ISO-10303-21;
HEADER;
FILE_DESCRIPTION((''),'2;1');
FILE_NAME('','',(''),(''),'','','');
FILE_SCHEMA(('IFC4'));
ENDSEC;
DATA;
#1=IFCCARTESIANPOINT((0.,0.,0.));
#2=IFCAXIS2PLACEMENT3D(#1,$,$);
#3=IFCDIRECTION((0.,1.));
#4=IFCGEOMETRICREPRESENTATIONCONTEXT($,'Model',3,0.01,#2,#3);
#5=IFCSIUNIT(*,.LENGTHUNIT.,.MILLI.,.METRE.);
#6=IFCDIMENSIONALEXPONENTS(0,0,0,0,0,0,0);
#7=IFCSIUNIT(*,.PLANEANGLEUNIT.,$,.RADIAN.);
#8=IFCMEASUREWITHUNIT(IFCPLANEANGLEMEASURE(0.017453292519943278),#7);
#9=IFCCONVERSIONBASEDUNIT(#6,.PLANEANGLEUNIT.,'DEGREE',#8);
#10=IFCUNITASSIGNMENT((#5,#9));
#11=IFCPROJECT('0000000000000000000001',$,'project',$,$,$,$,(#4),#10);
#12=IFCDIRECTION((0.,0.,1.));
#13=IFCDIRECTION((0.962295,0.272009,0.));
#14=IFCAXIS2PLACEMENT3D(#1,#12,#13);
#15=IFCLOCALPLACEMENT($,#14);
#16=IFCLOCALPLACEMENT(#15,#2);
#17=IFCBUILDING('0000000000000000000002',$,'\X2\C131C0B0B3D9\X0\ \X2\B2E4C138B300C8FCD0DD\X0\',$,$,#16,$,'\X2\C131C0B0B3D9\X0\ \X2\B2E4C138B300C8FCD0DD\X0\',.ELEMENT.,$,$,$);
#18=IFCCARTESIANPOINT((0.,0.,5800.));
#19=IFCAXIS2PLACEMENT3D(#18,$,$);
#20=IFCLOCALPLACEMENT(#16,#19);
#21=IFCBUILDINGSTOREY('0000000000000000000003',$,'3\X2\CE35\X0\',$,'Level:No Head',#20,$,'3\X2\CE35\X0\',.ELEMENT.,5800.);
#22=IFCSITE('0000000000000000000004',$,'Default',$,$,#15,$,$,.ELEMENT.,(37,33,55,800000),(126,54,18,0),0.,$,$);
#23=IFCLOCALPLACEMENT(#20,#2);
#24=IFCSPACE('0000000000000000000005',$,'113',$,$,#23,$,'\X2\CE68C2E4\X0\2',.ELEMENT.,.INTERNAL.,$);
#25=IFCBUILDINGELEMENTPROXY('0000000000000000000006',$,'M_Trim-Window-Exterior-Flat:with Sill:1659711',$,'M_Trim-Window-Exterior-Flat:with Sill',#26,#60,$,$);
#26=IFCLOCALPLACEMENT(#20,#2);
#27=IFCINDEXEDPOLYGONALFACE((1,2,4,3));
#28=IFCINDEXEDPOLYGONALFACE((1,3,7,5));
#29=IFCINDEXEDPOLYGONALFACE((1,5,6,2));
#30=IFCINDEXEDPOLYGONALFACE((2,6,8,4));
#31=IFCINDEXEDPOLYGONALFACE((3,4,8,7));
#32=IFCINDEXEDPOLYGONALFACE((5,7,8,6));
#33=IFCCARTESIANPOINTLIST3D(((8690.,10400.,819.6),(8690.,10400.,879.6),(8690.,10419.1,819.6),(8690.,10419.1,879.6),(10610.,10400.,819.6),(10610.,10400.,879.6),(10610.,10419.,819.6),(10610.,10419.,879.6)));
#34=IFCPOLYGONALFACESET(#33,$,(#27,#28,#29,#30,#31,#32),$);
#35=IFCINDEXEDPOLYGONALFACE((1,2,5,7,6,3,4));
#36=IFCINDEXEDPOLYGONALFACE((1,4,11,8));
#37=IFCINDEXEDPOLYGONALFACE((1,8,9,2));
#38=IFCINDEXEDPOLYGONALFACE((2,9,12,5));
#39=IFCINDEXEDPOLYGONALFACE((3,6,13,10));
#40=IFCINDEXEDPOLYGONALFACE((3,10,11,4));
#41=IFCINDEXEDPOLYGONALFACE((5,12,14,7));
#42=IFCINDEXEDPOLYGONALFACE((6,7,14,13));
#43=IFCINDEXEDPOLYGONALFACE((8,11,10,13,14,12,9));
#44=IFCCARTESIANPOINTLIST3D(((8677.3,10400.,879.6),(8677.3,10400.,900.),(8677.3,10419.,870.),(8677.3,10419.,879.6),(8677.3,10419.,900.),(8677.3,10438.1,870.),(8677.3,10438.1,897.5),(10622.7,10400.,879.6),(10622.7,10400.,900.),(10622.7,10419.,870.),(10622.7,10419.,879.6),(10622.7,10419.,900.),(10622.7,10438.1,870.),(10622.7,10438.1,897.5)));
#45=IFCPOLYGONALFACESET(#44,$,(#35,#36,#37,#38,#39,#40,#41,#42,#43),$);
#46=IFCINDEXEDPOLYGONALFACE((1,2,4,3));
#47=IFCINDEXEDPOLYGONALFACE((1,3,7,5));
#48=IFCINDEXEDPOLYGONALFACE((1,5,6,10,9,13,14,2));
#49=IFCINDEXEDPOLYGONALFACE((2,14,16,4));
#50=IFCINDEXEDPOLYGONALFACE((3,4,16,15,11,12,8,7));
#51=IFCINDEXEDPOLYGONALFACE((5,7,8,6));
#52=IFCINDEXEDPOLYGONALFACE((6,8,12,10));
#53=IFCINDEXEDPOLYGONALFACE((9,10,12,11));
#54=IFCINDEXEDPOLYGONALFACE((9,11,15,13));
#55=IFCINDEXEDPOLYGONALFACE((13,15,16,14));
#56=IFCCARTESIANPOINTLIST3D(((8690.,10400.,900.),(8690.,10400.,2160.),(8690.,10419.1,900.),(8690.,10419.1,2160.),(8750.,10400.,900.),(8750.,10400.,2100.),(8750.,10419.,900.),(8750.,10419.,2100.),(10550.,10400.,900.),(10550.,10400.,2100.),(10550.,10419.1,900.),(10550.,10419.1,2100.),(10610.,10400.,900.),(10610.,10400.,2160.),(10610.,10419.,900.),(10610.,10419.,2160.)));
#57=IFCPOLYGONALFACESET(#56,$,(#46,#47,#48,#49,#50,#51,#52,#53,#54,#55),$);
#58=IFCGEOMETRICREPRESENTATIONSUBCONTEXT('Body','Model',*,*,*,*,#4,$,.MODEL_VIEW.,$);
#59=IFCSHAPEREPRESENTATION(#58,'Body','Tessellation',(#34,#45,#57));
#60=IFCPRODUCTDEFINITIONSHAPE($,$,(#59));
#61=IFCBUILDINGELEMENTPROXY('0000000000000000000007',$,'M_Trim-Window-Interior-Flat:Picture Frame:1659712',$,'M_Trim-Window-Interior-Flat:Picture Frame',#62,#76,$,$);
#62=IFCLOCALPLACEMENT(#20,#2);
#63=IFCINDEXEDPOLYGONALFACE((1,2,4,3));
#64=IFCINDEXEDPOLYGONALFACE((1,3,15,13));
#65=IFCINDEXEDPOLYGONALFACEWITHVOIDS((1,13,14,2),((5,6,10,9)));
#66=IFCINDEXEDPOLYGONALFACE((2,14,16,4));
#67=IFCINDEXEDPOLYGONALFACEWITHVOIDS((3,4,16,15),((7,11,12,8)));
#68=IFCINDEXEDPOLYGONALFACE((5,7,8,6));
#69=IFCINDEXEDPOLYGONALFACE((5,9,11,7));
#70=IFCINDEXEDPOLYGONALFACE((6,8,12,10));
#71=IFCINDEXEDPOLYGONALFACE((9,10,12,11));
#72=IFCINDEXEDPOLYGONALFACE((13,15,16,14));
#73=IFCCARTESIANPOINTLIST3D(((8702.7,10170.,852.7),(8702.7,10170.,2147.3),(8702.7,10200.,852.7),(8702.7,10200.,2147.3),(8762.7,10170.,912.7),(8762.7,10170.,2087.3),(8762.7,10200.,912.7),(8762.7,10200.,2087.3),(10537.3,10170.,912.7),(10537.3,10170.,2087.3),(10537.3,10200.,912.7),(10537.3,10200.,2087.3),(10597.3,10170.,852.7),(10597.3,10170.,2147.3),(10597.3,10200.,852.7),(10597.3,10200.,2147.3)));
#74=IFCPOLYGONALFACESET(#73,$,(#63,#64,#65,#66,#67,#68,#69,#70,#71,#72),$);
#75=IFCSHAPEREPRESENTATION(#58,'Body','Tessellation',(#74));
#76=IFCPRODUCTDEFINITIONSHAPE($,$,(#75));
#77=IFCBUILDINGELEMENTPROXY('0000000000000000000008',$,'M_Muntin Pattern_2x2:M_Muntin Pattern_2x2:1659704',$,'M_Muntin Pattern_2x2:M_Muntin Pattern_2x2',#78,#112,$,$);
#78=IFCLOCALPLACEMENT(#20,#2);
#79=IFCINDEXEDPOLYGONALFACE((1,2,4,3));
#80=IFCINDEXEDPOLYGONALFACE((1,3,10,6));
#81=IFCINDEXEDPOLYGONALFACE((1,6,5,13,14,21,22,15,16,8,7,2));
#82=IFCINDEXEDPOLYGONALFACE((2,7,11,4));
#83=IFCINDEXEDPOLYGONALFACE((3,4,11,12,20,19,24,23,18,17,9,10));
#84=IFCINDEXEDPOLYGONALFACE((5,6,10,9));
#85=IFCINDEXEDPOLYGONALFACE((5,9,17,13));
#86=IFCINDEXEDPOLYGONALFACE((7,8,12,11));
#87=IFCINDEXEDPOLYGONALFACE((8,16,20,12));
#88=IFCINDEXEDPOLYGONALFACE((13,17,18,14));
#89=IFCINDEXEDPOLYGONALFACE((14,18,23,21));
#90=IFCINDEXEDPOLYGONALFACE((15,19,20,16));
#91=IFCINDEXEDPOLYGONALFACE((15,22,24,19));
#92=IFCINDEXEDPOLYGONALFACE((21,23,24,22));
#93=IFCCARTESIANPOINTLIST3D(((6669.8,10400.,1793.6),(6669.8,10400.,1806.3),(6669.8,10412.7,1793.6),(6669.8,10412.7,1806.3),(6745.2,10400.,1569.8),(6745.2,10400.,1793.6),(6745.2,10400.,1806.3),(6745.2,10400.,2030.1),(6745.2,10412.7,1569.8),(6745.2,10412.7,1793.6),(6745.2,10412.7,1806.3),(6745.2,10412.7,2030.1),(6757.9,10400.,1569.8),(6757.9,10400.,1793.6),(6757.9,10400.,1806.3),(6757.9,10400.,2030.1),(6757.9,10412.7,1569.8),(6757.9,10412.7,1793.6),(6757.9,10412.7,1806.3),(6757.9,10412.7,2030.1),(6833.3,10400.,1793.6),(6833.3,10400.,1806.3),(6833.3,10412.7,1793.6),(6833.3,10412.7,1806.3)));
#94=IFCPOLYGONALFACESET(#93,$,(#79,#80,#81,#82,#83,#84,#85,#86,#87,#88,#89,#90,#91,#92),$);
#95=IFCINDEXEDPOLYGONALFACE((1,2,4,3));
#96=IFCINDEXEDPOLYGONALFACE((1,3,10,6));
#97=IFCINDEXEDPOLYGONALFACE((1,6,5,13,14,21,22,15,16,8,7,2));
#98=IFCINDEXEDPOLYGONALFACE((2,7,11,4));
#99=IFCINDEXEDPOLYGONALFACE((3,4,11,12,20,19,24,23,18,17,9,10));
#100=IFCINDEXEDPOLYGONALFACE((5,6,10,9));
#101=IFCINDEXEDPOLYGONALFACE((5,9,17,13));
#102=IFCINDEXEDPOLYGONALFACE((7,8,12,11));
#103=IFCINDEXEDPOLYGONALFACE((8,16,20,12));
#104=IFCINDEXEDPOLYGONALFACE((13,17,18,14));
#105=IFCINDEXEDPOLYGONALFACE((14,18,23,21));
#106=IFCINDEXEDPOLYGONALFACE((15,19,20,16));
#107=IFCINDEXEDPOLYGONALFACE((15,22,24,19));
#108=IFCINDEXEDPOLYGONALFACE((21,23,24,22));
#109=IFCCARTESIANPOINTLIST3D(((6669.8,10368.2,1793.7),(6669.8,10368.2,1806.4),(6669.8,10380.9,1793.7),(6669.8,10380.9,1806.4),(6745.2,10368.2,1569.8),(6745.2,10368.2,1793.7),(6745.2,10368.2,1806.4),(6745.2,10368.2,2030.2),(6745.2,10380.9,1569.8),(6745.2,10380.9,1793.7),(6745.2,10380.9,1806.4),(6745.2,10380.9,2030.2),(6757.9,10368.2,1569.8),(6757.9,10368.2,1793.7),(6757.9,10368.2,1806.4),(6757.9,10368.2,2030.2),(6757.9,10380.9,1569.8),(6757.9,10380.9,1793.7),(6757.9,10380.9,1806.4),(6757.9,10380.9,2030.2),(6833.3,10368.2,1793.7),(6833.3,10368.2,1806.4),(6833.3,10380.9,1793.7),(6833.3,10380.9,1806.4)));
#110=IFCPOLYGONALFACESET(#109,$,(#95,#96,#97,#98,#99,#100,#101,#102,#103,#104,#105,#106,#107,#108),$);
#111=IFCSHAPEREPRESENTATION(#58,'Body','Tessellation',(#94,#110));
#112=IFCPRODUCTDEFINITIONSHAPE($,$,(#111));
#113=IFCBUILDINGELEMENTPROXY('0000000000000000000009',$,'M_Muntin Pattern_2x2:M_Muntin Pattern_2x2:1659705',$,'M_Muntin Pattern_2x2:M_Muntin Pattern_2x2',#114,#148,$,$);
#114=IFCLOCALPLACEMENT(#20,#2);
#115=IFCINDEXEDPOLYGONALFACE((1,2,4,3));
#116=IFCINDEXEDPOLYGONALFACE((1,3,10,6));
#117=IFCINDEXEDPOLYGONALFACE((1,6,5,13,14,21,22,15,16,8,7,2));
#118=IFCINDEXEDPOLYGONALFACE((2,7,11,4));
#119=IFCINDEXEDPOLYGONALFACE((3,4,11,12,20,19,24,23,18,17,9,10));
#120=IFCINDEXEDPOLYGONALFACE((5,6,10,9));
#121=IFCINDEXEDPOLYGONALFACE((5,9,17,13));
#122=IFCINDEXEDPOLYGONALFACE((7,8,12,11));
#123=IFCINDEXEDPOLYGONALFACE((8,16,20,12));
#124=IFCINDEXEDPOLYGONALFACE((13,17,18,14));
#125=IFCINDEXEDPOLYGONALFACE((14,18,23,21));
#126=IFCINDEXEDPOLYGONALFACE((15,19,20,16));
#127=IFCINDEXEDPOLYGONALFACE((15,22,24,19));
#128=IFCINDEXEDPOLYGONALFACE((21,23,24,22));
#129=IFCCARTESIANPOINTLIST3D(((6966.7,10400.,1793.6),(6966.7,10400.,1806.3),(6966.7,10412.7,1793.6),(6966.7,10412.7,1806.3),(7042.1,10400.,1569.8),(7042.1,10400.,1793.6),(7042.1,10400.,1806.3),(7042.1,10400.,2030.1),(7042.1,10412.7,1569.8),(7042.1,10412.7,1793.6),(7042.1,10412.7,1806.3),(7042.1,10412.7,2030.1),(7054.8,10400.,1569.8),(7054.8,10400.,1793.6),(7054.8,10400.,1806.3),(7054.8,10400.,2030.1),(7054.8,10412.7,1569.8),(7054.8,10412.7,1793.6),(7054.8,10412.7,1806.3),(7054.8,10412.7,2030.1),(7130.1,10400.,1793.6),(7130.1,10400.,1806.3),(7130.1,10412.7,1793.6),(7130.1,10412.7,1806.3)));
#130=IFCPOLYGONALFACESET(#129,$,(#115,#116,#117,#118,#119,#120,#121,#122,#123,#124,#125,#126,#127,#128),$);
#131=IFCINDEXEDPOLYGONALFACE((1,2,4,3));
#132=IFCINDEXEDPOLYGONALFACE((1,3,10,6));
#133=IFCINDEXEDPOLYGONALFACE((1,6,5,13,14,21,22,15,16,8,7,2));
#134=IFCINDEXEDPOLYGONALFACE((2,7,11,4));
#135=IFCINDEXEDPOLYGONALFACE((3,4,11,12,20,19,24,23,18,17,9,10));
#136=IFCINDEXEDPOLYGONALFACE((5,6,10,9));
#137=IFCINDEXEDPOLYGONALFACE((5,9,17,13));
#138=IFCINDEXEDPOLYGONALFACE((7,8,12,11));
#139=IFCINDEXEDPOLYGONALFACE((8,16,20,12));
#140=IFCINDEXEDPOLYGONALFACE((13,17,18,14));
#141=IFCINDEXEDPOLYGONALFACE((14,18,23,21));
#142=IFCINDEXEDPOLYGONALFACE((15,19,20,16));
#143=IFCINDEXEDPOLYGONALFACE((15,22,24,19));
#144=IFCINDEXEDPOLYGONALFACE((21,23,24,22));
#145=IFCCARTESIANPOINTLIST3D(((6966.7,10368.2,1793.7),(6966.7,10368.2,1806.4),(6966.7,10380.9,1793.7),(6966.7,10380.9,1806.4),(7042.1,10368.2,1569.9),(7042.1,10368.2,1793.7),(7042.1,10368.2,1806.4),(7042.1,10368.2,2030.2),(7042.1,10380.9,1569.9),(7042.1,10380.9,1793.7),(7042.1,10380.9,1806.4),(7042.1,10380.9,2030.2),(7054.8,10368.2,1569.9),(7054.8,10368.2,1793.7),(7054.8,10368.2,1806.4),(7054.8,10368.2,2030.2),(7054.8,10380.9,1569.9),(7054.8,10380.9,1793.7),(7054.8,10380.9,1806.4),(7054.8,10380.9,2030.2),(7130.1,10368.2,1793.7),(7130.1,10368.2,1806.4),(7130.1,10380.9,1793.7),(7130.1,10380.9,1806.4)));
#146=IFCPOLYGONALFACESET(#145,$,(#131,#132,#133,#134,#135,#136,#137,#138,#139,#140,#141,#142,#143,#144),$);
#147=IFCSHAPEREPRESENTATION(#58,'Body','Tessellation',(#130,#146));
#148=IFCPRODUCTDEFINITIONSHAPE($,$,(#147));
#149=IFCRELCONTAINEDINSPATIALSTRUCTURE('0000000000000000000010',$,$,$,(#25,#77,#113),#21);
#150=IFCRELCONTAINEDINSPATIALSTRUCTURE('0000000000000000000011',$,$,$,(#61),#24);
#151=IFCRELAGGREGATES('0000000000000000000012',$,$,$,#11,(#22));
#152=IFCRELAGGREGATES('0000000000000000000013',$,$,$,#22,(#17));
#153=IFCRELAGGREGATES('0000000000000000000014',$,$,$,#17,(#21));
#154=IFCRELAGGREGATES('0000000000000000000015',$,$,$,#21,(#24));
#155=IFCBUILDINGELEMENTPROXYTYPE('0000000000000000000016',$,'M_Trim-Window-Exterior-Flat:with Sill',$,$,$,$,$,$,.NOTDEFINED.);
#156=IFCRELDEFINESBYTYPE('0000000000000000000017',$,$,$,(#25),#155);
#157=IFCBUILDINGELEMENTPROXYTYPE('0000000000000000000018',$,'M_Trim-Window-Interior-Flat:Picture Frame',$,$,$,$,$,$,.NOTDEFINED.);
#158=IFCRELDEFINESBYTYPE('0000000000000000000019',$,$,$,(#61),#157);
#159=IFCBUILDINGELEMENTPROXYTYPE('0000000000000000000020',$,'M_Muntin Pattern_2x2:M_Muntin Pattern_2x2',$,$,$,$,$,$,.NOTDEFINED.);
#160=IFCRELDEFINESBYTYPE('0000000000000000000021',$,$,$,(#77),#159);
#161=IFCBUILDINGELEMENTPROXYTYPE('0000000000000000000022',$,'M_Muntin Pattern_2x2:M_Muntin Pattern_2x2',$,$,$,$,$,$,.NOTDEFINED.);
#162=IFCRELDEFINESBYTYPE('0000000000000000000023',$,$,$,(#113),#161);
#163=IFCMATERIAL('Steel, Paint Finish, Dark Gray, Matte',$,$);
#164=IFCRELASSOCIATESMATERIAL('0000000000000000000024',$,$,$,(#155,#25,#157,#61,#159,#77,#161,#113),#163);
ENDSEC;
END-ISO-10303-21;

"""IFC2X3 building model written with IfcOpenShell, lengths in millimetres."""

from ifc_helpers import new_model, entity, si_unit, converted_unit, direction, frame, frame_2d, origin, place, context, subcontext, project, spatial, polyline, rectangle, outline, extrude, source, transform, mapped, material, type_object, type_shapes, element, save


model = new_model("IFC2X3")

# Units and contexts
model_context = context("Model", 3, precision=0.01, world=origin(), true_north=direction((0.0, 1.0)))
body_context = subcontext(model_context, "Body", "Model", "MODEL_VIEW")
ifc_project = project(units=[si_unit("LENGTHUNIT", "METRE", prefix="MILLI"), converted_unit("PLANEANGLEUNIT", "DEGREE", entity("IfcPlaneAngleMeasure", 0.017453292519943278), si_unit("PLANEANGLEUNIT", "RADIAN"), dimensions=[0, 0, 0, 0, 0, 0, 0])], contexts=[model_context])

# Site, building, storey
site_placement = place(None, frame((0.0, 0.0, 0.0), z_axis=(0.0, 0.0, 1.0), x_axis=(0.962295, 0.272009, 0.0)))
site = spatial("IfcSite", under=ifc_project, at=site_placement, Name="Default", CompositionType="ELEMENT", RefLatitude=(37, 33, 55, 800000), RefLongitude=(126, 54, 18, 0), RefElevation=0.0)
building_placement = place(site_placement, origin())
building = spatial("IfcBuilding", under=site, at=building_placement, Name="성산동 다세대주택", LongName="성산동 다세대주택", CompositionType="ELEMENT")
storey_placement = place(building_placement, frame((0.0, 0.0, 5800.0)))
storey = spatial("IfcBuildingStorey", under=building, at=storey_placement, Name="3층", ObjectType="Level:No Head", LongName="3층", CompositionType="ELEMENT", Elevation=5800.0)

# Building element proxy
ifc_material_1 = material(Name="Steel, Paint Finish, Dark Gray, Matte")
building_element_proxy_type_1 = type_object("IfcBuildingElementProxyType", Name="M_Trim-Window-Exterior-Flat:with Sill", PredefinedType="NOTDEFINED", material=ifc_material_1)
shared_shape_1 = source(origin(), body_context, "Body", "SweptSolid", [
    extrude(rectangle(XDim=1920.0, YDim=60.0, at=frame_2d((0.0, 0.0), x_axis=(1.0, 0.0))), frame((0.0, -1250.4, 0.0), z_axis=(0.0, 0.0, 1.0), x_axis=(-1.0, 0.0, 0.0)), (0.0, 0.0, 1.0), 19.0),
    extrude(outline(polyline([(-19.0, -15.2), (0.0, -15.2), (0.0, -5.7), (19.0, -5.7), (19.0, 14.8), (0.0, 14.8), (-19.0, 12.3), (-19.0, -15.2)])), frame((-972.7, -1214.8, 19.0), z_axis=(1.0, 0.0, 0.0), x_axis=(0.0, 0.0, -1.0)), (0.0, 0.0, 1.0), 1945.4),
    extrude(outline(polyline([(-645.0, -960.0), (615.0, -960.0), (615.0, -900.0), (-585.0, -900.0), (-585.0, 900.0), (615.0, 900.0), (615.0, 960.0), (-645.0, 960.0), (-645.0, -960.0)])), frame((0.0, -585.0, 0.0), z_axis=(0.0, 0.0, 1.0), x_axis=(0.0, -1.0, 0.0)), (0.0, 0.0, 1.0), 19.0),
])
type_shapes(building_element_proxy_type_1, [shared_shape_1])
proxy_1_placement = place(storey_placement, frame((9650.0, 10400.0, 2100.0), z_axis=(0.0, 1.0, 0.0), x_axis=(-1.0, 0.0, 0.0)))
element("IfcBuildingElementProxy", 1, at=proxy_1_placement, inside=storey, type_object=building_element_proxy_type_1, material=ifc_material_1, Name="M_Trim-Window-Exterior-Flat:with Sill:1659711", ObjectType="M_Trim-Window-Exterior-Flat:with Sill", context=body_context, shape_type="MappedRepresentation", body=[
    mapped(shared_shape_1, transform((0.0, 0.0, 0.0), scale=1.0)),
])

# Shared definitions
space_1_placement = place(storey_placement, origin())
space_1 = spatial("IfcSpace", under=storey, at=space_1_placement, Name="113", LongName="침실2", CompositionType="ELEMENT", InteriorOrExteriorSpace="INTERNAL")

# Building element proxies
building_element_proxy_type_2 = type_object("IfcBuildingElementProxyType", Name="M_Trim-Window-Interior-Flat:Picture Frame", PredefinedType="NOTDEFINED", material=ifc_material_1)
shared_shape_2 = source(origin(), body_context, "Body", "SweptSolid", [
    extrude(outline(polyline([(-947.3, -647.3), (947.3, -647.3), (947.3, 647.3), (-947.3, 647.3), (-947.3, -647.3)]), holes=[polyline([(-887.3, -587.3), (-887.3, 587.3), (887.3, 587.3), (887.3, -587.3), (-887.3, -587.3)])]), frame((0.0, -600.0, 0.0), z_axis=(0.0, 0.0, 1.0), x_axis=(-1.0, 0.0, 0.0)), (0.0, 0.0, 1.0), 30.0),
])
type_shapes(building_element_proxy_type_2, [shared_shape_2])
proxy_2_placement = place(space_1_placement, frame((9650.0, 10200.0, 2100.0), z_axis=(0.0, -1.0, 0.0), x_axis=(1.0, 0.0, 0.0)))
element("IfcBuildingElementProxy", 2, at=proxy_2_placement, inside=space_1, type_object=building_element_proxy_type_2, material=ifc_material_1, Name="M_Trim-Window-Interior-Flat:Picture Frame:1659712", ObjectType="M_Trim-Window-Interior-Flat:Picture Frame", context=body_context, shape_type="MappedRepresentation", body=[
    mapped(shared_shape_2, transform((0.0, 0.0, 0.0), scale=1.0)),
])
building_element_proxy_type_3 = type_object("IfcBuildingElementProxyType", Name="M_Muntin Pattern_2x2:M_Muntin Pattern_2x2", PredefinedType="NOTDEFINED", material=ifc_material_1)
shared_shape_3 = source(origin(), body_context, "Body", "SweptSolid", [
    extrude(outline(polyline([(6.4, -6.4), (230.1, -6.4), (230.1, 6.3), (6.4, 6.3), (6.4, 81.7), (-6.3, 81.7), (-6.3, 6.3), (-230.2, 6.3), (-230.2, -6.4), (-6.3, -6.4), (-6.3, -81.7), (6.4, -81.7), (6.4, -6.4)])), frame((0.0, 9.5, 230.1), z_axis=(0.0, 1.0, 0.0), x_axis=(0.0, 0.0, 1.0)), (0.0, 0.0, 1.0), 12.7),
    extrude(outline(polyline([(6.4, -6.4), (230.2, -6.4), (230.2, 6.3), (6.4, 6.3), (6.4, 81.7), (-6.3, 81.7), (-6.3, 6.3), (-230.2, 6.3), (-230.2, -6.4), (-6.3, -6.4), (-6.3, -81.7), (6.4, -81.7), (6.4, -6.4)])), frame((0.0, -22.2, 230.2), z_axis=(0.0, 1.0, 0.0), x_axis=(0.0, 0.0, 1.0)), (0.0, 0.0, 1.0), 12.7),
])
type_shapes(building_element_proxy_type_3, [shared_shape_3])
proxy_3_placement = place(storey_placement, frame((6751.6, 10390.5, 1569.8)))
element("IfcBuildingElementProxy", 3, at=proxy_3_placement, inside=storey, type_object=building_element_proxy_type_3, material=ifc_material_1, Name="M_Muntin Pattern_2x2:M_Muntin Pattern_2x2:1659704", ObjectType="M_Muntin Pattern_2x2:M_Muntin Pattern_2x2", context=body_context, shape_type="MappedRepresentation", body=[
    mapped(shared_shape_3, transform((0.0, 0.0, 0.0), scale=1.0)),
])
building_element_proxy_type_4 = type_object("IfcBuildingElementProxyType", Name="M_Muntin Pattern_2x2:M_Muntin Pattern_2x2", PredefinedType="NOTDEFINED", material=ifc_material_1)
shared_shape_4 = source(origin(), body_context, "Body", "SweptSolid", [
    extrude(outline(polyline([(6.4, -6.4), (230.1, -6.4), (230.1, 6.3), (6.4, 6.3), (6.4, 81.7), (-6.3, 81.7), (-6.3, 6.3), (-230.2, 6.3), (-230.2, -6.4), (-6.3, -6.4), (-6.3, -81.7), (6.4, -81.7), (6.4, -6.4)])), frame((0.0, -22.2, 230.1), z_axis=(0.0, 1.0, 0.0), x_axis=(0.0, 0.0, 1.0)), (0.0, 0.0, 1.0), 12.7),
    extrude(outline(polyline([(6.4, -6.4), (230.2, -6.4), (230.2, 6.3), (6.4, 6.3), (6.4, 81.7), (-6.3, 81.7), (-6.3, 6.3), (-230.2, 6.3), (-230.2, -6.4), (-6.3, -6.4), (-6.3, -81.7), (6.4, -81.7), (6.4, -6.4)])), frame((0.0, 9.5, 230.2), z_axis=(0.0, 1.0, 0.0), x_axis=(0.0, 0.0, 1.0)), (0.0, 0.0, 1.0), 12.7),
])
type_shapes(building_element_proxy_type_4, [shared_shape_4])
proxy_4_placement = place(storey_placement, frame((7048.4, 10390.5, 1569.9), z_axis=(0.0, 0.0, 1.0), x_axis=(-1.0, 0.0, 0.0)))
element("IfcBuildingElementProxy", 4, at=proxy_4_placement, inside=storey, type_object=building_element_proxy_type_4, material=ifc_material_1, Name="M_Muntin Pattern_2x2:M_Muntin Pattern_2x2:1659705", ObjectType="M_Muntin Pattern_2x2:M_Muntin Pattern_2x2", context=body_context, shape_type="MappedRepresentation", body=[
    mapped(shared_shape_4, transform((0.0, 0.0, 0.0), scale=1.0)),
])

save(model, "model.ifc")
